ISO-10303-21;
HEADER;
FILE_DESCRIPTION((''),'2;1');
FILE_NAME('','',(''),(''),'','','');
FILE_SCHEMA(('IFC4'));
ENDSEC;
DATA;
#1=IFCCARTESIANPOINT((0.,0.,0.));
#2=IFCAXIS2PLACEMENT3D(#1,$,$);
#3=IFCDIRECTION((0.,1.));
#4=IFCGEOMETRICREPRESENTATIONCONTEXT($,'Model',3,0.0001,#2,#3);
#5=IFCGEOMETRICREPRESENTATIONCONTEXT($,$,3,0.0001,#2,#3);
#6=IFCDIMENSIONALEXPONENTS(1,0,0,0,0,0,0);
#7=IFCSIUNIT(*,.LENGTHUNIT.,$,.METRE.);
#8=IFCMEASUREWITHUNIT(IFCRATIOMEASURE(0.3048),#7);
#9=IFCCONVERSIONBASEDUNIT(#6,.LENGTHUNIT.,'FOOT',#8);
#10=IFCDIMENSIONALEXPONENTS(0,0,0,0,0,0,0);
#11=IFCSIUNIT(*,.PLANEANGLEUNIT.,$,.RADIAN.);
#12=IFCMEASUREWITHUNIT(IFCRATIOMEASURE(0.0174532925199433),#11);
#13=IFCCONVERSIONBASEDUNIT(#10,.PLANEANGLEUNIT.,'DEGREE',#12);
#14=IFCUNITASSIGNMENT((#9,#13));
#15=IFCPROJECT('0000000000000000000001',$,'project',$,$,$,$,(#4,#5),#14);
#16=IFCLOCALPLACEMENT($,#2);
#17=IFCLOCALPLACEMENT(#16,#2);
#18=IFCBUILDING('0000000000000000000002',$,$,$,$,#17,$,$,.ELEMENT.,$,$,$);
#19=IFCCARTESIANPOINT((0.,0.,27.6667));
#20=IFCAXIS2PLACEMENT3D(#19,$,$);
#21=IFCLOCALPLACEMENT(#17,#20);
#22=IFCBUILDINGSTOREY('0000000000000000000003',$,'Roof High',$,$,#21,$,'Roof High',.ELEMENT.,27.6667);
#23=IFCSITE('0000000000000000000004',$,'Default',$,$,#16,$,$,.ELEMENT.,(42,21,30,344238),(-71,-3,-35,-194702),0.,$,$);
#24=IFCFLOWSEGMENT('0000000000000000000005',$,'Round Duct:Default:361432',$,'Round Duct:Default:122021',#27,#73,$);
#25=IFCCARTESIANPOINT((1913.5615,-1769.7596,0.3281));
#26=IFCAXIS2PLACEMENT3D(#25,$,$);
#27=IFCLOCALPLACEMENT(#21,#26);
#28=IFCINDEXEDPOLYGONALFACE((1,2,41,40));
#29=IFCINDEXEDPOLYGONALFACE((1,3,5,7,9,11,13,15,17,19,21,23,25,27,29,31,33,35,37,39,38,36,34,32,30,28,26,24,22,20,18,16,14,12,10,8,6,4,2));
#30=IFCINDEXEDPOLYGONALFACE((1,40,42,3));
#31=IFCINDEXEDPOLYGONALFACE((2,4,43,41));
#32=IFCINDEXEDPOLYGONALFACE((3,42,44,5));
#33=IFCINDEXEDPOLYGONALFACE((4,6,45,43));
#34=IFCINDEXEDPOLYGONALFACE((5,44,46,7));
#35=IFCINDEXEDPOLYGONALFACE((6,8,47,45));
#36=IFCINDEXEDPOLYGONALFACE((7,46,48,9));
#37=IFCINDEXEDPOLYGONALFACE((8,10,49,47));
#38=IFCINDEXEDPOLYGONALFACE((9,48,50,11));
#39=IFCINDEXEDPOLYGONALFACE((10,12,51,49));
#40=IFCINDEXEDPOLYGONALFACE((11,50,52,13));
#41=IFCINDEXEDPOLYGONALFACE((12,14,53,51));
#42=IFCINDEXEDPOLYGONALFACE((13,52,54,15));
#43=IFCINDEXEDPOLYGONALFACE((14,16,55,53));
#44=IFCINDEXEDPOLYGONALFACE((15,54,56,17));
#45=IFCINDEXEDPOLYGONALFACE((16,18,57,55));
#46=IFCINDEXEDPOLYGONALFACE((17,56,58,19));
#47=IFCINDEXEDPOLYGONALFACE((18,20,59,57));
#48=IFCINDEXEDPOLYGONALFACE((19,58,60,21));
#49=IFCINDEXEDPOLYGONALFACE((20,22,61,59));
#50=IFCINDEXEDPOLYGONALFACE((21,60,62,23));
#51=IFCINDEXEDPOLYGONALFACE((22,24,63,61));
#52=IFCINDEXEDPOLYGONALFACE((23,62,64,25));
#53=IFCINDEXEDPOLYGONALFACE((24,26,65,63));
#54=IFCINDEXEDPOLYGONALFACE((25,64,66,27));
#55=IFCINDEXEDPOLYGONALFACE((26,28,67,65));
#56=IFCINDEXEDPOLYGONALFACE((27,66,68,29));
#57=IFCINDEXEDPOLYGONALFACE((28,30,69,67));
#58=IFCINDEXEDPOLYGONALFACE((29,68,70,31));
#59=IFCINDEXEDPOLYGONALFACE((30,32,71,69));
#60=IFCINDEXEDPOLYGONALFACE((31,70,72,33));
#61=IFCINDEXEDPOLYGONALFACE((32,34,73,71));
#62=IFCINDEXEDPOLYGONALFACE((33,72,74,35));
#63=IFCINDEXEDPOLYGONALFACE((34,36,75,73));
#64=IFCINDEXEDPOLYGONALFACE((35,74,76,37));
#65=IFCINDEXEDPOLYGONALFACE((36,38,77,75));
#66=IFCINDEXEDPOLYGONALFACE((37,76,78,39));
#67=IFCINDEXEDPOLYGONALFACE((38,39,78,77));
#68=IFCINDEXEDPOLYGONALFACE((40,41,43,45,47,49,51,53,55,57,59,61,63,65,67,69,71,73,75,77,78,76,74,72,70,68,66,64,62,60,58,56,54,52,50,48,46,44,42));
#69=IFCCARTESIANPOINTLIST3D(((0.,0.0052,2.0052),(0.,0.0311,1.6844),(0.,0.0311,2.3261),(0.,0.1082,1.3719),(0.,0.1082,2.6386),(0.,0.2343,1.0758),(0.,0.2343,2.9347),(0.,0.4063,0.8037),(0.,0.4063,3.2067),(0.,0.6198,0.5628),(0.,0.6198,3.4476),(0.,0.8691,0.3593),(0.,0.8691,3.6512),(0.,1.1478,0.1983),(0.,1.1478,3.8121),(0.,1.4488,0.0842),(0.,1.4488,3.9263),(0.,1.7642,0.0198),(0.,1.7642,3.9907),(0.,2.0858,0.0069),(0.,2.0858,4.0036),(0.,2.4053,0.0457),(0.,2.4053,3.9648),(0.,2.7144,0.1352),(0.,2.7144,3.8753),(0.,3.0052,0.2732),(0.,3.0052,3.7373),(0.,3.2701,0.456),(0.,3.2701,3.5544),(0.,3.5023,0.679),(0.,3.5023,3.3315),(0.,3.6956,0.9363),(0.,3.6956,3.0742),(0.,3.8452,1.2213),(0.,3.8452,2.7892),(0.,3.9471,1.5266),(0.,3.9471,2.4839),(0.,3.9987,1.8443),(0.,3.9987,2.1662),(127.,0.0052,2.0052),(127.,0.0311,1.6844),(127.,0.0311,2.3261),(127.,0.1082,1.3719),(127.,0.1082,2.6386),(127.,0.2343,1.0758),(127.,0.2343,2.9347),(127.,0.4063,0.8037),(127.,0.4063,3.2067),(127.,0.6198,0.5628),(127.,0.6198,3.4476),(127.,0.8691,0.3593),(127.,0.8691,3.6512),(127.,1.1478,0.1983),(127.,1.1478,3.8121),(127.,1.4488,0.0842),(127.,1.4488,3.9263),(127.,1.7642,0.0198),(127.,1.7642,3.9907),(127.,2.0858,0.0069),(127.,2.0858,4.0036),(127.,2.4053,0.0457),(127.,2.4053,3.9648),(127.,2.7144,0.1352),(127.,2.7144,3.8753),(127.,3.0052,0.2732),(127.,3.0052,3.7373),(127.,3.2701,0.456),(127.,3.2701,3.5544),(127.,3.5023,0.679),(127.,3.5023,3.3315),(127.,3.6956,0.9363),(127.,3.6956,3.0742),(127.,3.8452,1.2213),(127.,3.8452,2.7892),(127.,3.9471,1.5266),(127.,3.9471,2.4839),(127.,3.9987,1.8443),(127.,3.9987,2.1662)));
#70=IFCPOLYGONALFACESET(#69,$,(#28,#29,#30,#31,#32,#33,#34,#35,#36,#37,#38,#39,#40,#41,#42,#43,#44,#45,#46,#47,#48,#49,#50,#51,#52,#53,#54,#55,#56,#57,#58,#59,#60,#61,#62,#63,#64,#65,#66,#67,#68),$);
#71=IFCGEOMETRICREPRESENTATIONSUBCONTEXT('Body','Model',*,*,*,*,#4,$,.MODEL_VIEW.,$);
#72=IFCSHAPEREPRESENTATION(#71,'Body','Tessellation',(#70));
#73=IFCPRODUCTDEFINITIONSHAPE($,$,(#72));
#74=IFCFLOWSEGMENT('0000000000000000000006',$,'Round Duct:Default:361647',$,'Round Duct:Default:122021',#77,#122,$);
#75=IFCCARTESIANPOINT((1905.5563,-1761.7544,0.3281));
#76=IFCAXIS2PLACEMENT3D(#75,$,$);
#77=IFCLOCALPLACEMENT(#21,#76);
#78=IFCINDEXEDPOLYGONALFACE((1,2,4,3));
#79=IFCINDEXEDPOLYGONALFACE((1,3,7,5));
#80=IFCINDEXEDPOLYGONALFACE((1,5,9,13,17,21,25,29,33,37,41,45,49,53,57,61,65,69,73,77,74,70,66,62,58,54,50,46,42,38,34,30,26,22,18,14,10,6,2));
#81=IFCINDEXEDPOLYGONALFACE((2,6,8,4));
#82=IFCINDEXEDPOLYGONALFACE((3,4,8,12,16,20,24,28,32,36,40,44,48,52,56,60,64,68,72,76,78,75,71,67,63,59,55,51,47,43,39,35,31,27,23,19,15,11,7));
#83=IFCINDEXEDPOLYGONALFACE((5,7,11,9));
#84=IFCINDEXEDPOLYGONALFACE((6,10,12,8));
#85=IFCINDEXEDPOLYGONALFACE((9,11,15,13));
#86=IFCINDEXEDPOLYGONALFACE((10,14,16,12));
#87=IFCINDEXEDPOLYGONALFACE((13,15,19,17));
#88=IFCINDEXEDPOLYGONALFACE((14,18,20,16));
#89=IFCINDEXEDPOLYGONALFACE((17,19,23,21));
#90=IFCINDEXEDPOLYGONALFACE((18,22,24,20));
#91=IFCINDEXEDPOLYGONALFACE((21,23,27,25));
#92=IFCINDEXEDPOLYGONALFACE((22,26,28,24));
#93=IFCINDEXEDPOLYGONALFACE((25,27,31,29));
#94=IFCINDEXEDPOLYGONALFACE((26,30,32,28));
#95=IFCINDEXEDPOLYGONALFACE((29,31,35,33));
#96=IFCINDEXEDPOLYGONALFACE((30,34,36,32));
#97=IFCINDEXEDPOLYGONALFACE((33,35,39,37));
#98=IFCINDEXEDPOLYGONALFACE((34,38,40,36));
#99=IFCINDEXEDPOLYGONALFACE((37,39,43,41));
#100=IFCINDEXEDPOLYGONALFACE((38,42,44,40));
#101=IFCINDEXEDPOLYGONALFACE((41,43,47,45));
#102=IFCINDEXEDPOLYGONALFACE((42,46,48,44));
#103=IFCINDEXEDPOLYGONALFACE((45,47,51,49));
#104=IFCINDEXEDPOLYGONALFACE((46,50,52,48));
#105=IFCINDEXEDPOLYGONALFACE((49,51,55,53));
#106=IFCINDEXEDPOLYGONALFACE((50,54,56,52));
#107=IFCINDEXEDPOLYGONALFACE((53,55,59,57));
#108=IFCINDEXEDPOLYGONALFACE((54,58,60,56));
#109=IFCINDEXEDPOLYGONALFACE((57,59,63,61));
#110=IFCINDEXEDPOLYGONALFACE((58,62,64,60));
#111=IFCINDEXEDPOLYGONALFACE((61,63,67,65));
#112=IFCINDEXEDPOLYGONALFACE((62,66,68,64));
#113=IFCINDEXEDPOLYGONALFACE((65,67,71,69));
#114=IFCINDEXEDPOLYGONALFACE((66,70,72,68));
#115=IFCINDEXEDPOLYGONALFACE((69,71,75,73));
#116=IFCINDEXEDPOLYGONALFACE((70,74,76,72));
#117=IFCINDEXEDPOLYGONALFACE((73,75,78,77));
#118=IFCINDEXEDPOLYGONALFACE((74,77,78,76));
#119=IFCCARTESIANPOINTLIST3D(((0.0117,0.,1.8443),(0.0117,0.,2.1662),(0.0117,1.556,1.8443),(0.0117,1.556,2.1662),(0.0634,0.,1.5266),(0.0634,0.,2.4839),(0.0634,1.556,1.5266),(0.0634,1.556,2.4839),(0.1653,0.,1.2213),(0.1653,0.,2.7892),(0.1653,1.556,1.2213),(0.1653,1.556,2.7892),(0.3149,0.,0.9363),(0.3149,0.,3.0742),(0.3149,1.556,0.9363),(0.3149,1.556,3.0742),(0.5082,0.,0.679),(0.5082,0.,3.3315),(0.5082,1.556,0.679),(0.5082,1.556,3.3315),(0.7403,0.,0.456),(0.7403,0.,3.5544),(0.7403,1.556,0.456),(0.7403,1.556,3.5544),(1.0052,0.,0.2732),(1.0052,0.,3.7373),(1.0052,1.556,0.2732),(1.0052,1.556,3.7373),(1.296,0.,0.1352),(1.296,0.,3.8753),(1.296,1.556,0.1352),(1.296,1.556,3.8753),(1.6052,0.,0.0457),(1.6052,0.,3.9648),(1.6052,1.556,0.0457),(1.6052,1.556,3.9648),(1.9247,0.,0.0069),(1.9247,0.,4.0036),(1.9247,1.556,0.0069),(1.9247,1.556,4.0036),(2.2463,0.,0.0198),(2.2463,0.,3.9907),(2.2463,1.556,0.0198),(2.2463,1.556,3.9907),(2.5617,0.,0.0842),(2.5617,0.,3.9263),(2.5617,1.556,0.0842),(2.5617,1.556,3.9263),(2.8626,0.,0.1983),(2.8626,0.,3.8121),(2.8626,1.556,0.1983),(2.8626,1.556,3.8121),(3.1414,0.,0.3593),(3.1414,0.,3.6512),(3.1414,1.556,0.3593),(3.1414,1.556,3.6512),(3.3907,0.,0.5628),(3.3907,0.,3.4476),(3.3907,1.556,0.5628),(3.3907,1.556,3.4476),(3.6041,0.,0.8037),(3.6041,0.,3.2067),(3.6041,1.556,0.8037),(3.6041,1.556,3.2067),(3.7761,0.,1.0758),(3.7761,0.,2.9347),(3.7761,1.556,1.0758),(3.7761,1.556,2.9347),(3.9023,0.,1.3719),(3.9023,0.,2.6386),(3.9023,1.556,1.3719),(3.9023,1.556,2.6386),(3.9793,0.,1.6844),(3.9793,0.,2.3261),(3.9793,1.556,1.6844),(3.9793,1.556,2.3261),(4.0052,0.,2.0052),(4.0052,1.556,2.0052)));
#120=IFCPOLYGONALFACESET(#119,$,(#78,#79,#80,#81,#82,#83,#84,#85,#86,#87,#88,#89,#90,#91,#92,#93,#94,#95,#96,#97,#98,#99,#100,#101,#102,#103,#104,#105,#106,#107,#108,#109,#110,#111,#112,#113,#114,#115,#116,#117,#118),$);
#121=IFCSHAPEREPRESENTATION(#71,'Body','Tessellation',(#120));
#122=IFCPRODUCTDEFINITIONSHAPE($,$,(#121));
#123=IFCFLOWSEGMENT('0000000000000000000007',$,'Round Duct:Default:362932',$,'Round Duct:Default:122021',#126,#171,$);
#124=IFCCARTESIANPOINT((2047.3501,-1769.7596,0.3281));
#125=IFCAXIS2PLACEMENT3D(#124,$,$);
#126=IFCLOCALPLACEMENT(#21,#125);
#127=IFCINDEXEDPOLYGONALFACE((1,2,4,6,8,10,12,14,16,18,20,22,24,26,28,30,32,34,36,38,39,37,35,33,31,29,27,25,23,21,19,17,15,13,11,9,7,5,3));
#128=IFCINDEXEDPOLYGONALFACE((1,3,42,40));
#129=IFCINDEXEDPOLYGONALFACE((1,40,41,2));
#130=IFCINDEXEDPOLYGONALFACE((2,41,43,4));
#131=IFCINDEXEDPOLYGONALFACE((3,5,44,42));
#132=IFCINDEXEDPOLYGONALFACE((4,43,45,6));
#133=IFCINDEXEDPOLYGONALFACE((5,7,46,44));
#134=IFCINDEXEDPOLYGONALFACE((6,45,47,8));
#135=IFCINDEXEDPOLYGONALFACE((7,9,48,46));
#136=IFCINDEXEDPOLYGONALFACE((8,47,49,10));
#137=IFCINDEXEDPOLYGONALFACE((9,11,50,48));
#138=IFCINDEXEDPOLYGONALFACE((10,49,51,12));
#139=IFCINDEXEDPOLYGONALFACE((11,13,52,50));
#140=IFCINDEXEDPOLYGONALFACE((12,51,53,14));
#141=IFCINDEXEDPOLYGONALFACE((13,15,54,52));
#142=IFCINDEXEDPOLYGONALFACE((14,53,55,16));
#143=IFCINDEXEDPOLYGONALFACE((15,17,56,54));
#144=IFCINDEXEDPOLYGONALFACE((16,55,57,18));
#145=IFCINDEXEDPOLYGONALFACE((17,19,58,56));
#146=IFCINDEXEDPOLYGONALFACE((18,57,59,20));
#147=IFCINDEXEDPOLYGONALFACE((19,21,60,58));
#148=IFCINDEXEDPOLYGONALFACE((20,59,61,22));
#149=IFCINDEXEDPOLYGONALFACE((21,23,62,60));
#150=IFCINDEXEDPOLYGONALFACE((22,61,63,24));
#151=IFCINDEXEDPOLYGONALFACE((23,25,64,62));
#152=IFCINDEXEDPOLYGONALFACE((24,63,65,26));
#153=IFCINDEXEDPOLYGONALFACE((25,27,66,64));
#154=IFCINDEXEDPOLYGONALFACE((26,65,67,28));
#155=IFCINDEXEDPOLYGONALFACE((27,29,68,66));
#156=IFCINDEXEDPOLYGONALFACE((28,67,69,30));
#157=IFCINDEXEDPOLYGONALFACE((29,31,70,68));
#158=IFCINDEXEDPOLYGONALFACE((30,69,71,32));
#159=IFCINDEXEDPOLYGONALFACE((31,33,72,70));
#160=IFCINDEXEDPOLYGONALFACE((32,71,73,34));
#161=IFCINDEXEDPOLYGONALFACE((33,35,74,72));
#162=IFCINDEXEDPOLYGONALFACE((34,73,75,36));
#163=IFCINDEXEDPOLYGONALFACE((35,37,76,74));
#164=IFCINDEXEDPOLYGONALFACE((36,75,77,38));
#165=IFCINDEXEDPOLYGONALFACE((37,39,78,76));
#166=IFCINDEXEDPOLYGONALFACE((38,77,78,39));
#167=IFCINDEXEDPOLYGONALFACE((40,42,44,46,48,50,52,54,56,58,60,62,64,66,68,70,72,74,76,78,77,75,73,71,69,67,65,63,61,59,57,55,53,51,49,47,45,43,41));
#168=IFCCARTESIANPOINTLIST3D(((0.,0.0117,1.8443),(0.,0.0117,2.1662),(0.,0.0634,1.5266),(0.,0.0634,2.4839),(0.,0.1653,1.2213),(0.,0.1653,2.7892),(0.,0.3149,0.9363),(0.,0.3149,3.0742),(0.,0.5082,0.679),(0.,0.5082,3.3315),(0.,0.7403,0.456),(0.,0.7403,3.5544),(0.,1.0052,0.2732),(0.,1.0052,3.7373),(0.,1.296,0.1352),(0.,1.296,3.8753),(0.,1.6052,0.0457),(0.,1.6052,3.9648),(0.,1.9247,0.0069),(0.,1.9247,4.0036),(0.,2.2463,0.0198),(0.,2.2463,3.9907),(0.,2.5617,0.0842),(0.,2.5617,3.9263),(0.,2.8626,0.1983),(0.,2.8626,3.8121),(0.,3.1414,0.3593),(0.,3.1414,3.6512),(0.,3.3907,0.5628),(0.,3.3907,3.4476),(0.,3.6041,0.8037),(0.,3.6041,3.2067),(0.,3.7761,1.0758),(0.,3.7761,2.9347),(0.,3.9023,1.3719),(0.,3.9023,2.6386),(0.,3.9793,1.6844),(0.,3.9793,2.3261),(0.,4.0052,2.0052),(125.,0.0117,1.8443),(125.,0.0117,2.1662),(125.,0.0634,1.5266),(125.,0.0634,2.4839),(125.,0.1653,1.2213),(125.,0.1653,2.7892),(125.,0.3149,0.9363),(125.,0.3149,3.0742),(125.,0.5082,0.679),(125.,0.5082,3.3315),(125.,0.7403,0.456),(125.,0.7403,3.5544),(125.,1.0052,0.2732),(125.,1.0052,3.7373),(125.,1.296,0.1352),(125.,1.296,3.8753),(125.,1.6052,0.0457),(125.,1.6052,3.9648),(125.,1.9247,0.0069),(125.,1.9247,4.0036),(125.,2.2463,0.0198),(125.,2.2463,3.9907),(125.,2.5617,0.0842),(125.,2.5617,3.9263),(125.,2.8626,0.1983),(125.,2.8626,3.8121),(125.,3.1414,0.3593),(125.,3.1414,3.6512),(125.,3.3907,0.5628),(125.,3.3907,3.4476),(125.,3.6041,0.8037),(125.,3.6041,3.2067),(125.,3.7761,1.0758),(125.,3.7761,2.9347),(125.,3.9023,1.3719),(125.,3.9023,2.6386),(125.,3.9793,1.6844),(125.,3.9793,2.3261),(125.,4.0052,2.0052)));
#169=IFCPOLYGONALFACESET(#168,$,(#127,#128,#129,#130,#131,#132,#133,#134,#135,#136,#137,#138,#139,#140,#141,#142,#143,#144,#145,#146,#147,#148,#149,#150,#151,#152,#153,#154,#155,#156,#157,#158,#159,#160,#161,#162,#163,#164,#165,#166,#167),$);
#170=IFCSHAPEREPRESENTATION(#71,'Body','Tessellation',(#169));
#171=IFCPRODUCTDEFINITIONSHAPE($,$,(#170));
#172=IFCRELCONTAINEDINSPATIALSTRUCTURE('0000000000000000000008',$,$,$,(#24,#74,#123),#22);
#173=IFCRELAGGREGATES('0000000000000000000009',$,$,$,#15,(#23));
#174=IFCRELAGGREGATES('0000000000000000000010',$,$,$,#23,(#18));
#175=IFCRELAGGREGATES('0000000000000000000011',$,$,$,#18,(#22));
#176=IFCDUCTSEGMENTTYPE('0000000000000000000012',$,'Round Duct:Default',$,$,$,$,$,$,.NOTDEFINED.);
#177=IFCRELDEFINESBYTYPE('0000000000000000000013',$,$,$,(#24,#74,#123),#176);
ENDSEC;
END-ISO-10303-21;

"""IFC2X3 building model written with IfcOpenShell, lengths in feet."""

from ifc_helpers import new_model, entity, si_unit, converted_unit, direction, frame, origin, origin_2d_with_axis, place, context, subcontext, project, spatial, circle, extrude, type_object, element, save


model = new_model("IFC2X3")

# Units and contexts
model_context = context("Model", 3, precision=0.0001, world=origin(), true_north=direction((0.0, 1.0)))
context_of_model = context(None, 3, precision=0.0001, world=origin(), true_north=direction((0.0, 1.0)))
body_context = subcontext(model_context, "Body", "Model", "MODEL_VIEW")
ifc_project = project(units=[converted_unit("LENGTHUNIT", "FOOT", entity("IfcRatioMeasure", 0.3048), si_unit("LENGTHUNIT", "METRE"), dimensions=[1, 0, 0, 0, 0, 0, 0]), converted_unit("PLANEANGLEUNIT", "DEGREE", entity("IfcRatioMeasure", 0.0174532925199433), si_unit("PLANEANGLEUNIT", "RADIAN"), dimensions=[0, 0, 0, 0, 0, 0, 0])], contexts=[model_context, context_of_model])

# Site, building, storey
site_placement = place(None, origin())
site = spatial("IfcSite", under=ifc_project, at=site_placement, Name="Default", CompositionType="ELEMENT", RefLatitude=(42, 21, 30, 344238), RefLongitude=(-71, -3, -35, -194702), RefElevation=0.0)
building_placement = place(site_placement, origin())
building = spatial("IfcBuilding", under=site, at=building_placement, CompositionType="ELEMENT")
storey_placement = place(building_placement, frame((0.0, 0.0, 27.6667)))
storey = spatial("IfcBuildingStorey", under=building, at=storey_placement, Name="Roof High", LongName="Roof High", CompositionType="ELEMENT", Elevation=27.6667)

# Flow segments
duct_segment_type = type_object("IfcDuctSegmentType", Name="Round Duct:Default", PredefinedType="NOTDEFINED")
flow_segment_1_placement = place(storey_placement, frame((1913.5615, -1769.7596, 0.3281)))
element("IfcFlowSegment", 1, at=flow_segment_1_placement, inside=storey, type_object=duct_segment_type, Name="Round Duct:Default:361432", ObjectType="Round Duct:Default:122021", context=body_context, shape_type="SweptSolid", body=[
    extrude(circle(Radius=2.0, at=origin_2d_with_axis()), frame((0.0, 2.0052, 2.0052), z_axis=(1.0, 0.0, 0.0), x_axis=(0.0, -1.0, 0.0)), (0.0, 0.0, 1.0), 127.0),
])
flow_segment_2_placement = place(storey_placement, frame((1905.5563, -1761.7544, 0.3281)))
element("IfcFlowSegment", 2, at=flow_segment_2_placement, inside=storey, type_object=duct_segment_type, Name="Round Duct:Default:361647", ObjectType="Round Duct:Default:122021", context=body_context, shape_type="SweptSolid", body=[
    extrude(circle(Radius=2.0, at=origin_2d_with_axis()), frame((2.0052, 0.0, 2.0052), z_axis=(0.0, 1.0, 0.0), x_axis=(1.0, 0.0, 0.0)), (0.0, 0.0, 1.0), 1.556),
])
flow_segment_3_placement = place(storey_placement, frame((2047.3501, -1769.7596, 0.3281)))
element("IfcFlowSegment", 3, at=flow_segment_3_placement, inside=storey, type_object=duct_segment_type, Name="Round Duct:Default:362932", ObjectType="Round Duct:Default:122021", context=body_context, shape_type="SweptSolid", body=[
    extrude(circle(Radius=2.0, at=origin_2d_with_axis()), frame((0.0, 2.0052, 2.0052), z_axis=(1.0, 0.0, 0.0), x_axis=(0.0, 1.0, 0.0)), (0.0, 0.0, 1.0), 125.0),
])

save(model, "model.ifc")
